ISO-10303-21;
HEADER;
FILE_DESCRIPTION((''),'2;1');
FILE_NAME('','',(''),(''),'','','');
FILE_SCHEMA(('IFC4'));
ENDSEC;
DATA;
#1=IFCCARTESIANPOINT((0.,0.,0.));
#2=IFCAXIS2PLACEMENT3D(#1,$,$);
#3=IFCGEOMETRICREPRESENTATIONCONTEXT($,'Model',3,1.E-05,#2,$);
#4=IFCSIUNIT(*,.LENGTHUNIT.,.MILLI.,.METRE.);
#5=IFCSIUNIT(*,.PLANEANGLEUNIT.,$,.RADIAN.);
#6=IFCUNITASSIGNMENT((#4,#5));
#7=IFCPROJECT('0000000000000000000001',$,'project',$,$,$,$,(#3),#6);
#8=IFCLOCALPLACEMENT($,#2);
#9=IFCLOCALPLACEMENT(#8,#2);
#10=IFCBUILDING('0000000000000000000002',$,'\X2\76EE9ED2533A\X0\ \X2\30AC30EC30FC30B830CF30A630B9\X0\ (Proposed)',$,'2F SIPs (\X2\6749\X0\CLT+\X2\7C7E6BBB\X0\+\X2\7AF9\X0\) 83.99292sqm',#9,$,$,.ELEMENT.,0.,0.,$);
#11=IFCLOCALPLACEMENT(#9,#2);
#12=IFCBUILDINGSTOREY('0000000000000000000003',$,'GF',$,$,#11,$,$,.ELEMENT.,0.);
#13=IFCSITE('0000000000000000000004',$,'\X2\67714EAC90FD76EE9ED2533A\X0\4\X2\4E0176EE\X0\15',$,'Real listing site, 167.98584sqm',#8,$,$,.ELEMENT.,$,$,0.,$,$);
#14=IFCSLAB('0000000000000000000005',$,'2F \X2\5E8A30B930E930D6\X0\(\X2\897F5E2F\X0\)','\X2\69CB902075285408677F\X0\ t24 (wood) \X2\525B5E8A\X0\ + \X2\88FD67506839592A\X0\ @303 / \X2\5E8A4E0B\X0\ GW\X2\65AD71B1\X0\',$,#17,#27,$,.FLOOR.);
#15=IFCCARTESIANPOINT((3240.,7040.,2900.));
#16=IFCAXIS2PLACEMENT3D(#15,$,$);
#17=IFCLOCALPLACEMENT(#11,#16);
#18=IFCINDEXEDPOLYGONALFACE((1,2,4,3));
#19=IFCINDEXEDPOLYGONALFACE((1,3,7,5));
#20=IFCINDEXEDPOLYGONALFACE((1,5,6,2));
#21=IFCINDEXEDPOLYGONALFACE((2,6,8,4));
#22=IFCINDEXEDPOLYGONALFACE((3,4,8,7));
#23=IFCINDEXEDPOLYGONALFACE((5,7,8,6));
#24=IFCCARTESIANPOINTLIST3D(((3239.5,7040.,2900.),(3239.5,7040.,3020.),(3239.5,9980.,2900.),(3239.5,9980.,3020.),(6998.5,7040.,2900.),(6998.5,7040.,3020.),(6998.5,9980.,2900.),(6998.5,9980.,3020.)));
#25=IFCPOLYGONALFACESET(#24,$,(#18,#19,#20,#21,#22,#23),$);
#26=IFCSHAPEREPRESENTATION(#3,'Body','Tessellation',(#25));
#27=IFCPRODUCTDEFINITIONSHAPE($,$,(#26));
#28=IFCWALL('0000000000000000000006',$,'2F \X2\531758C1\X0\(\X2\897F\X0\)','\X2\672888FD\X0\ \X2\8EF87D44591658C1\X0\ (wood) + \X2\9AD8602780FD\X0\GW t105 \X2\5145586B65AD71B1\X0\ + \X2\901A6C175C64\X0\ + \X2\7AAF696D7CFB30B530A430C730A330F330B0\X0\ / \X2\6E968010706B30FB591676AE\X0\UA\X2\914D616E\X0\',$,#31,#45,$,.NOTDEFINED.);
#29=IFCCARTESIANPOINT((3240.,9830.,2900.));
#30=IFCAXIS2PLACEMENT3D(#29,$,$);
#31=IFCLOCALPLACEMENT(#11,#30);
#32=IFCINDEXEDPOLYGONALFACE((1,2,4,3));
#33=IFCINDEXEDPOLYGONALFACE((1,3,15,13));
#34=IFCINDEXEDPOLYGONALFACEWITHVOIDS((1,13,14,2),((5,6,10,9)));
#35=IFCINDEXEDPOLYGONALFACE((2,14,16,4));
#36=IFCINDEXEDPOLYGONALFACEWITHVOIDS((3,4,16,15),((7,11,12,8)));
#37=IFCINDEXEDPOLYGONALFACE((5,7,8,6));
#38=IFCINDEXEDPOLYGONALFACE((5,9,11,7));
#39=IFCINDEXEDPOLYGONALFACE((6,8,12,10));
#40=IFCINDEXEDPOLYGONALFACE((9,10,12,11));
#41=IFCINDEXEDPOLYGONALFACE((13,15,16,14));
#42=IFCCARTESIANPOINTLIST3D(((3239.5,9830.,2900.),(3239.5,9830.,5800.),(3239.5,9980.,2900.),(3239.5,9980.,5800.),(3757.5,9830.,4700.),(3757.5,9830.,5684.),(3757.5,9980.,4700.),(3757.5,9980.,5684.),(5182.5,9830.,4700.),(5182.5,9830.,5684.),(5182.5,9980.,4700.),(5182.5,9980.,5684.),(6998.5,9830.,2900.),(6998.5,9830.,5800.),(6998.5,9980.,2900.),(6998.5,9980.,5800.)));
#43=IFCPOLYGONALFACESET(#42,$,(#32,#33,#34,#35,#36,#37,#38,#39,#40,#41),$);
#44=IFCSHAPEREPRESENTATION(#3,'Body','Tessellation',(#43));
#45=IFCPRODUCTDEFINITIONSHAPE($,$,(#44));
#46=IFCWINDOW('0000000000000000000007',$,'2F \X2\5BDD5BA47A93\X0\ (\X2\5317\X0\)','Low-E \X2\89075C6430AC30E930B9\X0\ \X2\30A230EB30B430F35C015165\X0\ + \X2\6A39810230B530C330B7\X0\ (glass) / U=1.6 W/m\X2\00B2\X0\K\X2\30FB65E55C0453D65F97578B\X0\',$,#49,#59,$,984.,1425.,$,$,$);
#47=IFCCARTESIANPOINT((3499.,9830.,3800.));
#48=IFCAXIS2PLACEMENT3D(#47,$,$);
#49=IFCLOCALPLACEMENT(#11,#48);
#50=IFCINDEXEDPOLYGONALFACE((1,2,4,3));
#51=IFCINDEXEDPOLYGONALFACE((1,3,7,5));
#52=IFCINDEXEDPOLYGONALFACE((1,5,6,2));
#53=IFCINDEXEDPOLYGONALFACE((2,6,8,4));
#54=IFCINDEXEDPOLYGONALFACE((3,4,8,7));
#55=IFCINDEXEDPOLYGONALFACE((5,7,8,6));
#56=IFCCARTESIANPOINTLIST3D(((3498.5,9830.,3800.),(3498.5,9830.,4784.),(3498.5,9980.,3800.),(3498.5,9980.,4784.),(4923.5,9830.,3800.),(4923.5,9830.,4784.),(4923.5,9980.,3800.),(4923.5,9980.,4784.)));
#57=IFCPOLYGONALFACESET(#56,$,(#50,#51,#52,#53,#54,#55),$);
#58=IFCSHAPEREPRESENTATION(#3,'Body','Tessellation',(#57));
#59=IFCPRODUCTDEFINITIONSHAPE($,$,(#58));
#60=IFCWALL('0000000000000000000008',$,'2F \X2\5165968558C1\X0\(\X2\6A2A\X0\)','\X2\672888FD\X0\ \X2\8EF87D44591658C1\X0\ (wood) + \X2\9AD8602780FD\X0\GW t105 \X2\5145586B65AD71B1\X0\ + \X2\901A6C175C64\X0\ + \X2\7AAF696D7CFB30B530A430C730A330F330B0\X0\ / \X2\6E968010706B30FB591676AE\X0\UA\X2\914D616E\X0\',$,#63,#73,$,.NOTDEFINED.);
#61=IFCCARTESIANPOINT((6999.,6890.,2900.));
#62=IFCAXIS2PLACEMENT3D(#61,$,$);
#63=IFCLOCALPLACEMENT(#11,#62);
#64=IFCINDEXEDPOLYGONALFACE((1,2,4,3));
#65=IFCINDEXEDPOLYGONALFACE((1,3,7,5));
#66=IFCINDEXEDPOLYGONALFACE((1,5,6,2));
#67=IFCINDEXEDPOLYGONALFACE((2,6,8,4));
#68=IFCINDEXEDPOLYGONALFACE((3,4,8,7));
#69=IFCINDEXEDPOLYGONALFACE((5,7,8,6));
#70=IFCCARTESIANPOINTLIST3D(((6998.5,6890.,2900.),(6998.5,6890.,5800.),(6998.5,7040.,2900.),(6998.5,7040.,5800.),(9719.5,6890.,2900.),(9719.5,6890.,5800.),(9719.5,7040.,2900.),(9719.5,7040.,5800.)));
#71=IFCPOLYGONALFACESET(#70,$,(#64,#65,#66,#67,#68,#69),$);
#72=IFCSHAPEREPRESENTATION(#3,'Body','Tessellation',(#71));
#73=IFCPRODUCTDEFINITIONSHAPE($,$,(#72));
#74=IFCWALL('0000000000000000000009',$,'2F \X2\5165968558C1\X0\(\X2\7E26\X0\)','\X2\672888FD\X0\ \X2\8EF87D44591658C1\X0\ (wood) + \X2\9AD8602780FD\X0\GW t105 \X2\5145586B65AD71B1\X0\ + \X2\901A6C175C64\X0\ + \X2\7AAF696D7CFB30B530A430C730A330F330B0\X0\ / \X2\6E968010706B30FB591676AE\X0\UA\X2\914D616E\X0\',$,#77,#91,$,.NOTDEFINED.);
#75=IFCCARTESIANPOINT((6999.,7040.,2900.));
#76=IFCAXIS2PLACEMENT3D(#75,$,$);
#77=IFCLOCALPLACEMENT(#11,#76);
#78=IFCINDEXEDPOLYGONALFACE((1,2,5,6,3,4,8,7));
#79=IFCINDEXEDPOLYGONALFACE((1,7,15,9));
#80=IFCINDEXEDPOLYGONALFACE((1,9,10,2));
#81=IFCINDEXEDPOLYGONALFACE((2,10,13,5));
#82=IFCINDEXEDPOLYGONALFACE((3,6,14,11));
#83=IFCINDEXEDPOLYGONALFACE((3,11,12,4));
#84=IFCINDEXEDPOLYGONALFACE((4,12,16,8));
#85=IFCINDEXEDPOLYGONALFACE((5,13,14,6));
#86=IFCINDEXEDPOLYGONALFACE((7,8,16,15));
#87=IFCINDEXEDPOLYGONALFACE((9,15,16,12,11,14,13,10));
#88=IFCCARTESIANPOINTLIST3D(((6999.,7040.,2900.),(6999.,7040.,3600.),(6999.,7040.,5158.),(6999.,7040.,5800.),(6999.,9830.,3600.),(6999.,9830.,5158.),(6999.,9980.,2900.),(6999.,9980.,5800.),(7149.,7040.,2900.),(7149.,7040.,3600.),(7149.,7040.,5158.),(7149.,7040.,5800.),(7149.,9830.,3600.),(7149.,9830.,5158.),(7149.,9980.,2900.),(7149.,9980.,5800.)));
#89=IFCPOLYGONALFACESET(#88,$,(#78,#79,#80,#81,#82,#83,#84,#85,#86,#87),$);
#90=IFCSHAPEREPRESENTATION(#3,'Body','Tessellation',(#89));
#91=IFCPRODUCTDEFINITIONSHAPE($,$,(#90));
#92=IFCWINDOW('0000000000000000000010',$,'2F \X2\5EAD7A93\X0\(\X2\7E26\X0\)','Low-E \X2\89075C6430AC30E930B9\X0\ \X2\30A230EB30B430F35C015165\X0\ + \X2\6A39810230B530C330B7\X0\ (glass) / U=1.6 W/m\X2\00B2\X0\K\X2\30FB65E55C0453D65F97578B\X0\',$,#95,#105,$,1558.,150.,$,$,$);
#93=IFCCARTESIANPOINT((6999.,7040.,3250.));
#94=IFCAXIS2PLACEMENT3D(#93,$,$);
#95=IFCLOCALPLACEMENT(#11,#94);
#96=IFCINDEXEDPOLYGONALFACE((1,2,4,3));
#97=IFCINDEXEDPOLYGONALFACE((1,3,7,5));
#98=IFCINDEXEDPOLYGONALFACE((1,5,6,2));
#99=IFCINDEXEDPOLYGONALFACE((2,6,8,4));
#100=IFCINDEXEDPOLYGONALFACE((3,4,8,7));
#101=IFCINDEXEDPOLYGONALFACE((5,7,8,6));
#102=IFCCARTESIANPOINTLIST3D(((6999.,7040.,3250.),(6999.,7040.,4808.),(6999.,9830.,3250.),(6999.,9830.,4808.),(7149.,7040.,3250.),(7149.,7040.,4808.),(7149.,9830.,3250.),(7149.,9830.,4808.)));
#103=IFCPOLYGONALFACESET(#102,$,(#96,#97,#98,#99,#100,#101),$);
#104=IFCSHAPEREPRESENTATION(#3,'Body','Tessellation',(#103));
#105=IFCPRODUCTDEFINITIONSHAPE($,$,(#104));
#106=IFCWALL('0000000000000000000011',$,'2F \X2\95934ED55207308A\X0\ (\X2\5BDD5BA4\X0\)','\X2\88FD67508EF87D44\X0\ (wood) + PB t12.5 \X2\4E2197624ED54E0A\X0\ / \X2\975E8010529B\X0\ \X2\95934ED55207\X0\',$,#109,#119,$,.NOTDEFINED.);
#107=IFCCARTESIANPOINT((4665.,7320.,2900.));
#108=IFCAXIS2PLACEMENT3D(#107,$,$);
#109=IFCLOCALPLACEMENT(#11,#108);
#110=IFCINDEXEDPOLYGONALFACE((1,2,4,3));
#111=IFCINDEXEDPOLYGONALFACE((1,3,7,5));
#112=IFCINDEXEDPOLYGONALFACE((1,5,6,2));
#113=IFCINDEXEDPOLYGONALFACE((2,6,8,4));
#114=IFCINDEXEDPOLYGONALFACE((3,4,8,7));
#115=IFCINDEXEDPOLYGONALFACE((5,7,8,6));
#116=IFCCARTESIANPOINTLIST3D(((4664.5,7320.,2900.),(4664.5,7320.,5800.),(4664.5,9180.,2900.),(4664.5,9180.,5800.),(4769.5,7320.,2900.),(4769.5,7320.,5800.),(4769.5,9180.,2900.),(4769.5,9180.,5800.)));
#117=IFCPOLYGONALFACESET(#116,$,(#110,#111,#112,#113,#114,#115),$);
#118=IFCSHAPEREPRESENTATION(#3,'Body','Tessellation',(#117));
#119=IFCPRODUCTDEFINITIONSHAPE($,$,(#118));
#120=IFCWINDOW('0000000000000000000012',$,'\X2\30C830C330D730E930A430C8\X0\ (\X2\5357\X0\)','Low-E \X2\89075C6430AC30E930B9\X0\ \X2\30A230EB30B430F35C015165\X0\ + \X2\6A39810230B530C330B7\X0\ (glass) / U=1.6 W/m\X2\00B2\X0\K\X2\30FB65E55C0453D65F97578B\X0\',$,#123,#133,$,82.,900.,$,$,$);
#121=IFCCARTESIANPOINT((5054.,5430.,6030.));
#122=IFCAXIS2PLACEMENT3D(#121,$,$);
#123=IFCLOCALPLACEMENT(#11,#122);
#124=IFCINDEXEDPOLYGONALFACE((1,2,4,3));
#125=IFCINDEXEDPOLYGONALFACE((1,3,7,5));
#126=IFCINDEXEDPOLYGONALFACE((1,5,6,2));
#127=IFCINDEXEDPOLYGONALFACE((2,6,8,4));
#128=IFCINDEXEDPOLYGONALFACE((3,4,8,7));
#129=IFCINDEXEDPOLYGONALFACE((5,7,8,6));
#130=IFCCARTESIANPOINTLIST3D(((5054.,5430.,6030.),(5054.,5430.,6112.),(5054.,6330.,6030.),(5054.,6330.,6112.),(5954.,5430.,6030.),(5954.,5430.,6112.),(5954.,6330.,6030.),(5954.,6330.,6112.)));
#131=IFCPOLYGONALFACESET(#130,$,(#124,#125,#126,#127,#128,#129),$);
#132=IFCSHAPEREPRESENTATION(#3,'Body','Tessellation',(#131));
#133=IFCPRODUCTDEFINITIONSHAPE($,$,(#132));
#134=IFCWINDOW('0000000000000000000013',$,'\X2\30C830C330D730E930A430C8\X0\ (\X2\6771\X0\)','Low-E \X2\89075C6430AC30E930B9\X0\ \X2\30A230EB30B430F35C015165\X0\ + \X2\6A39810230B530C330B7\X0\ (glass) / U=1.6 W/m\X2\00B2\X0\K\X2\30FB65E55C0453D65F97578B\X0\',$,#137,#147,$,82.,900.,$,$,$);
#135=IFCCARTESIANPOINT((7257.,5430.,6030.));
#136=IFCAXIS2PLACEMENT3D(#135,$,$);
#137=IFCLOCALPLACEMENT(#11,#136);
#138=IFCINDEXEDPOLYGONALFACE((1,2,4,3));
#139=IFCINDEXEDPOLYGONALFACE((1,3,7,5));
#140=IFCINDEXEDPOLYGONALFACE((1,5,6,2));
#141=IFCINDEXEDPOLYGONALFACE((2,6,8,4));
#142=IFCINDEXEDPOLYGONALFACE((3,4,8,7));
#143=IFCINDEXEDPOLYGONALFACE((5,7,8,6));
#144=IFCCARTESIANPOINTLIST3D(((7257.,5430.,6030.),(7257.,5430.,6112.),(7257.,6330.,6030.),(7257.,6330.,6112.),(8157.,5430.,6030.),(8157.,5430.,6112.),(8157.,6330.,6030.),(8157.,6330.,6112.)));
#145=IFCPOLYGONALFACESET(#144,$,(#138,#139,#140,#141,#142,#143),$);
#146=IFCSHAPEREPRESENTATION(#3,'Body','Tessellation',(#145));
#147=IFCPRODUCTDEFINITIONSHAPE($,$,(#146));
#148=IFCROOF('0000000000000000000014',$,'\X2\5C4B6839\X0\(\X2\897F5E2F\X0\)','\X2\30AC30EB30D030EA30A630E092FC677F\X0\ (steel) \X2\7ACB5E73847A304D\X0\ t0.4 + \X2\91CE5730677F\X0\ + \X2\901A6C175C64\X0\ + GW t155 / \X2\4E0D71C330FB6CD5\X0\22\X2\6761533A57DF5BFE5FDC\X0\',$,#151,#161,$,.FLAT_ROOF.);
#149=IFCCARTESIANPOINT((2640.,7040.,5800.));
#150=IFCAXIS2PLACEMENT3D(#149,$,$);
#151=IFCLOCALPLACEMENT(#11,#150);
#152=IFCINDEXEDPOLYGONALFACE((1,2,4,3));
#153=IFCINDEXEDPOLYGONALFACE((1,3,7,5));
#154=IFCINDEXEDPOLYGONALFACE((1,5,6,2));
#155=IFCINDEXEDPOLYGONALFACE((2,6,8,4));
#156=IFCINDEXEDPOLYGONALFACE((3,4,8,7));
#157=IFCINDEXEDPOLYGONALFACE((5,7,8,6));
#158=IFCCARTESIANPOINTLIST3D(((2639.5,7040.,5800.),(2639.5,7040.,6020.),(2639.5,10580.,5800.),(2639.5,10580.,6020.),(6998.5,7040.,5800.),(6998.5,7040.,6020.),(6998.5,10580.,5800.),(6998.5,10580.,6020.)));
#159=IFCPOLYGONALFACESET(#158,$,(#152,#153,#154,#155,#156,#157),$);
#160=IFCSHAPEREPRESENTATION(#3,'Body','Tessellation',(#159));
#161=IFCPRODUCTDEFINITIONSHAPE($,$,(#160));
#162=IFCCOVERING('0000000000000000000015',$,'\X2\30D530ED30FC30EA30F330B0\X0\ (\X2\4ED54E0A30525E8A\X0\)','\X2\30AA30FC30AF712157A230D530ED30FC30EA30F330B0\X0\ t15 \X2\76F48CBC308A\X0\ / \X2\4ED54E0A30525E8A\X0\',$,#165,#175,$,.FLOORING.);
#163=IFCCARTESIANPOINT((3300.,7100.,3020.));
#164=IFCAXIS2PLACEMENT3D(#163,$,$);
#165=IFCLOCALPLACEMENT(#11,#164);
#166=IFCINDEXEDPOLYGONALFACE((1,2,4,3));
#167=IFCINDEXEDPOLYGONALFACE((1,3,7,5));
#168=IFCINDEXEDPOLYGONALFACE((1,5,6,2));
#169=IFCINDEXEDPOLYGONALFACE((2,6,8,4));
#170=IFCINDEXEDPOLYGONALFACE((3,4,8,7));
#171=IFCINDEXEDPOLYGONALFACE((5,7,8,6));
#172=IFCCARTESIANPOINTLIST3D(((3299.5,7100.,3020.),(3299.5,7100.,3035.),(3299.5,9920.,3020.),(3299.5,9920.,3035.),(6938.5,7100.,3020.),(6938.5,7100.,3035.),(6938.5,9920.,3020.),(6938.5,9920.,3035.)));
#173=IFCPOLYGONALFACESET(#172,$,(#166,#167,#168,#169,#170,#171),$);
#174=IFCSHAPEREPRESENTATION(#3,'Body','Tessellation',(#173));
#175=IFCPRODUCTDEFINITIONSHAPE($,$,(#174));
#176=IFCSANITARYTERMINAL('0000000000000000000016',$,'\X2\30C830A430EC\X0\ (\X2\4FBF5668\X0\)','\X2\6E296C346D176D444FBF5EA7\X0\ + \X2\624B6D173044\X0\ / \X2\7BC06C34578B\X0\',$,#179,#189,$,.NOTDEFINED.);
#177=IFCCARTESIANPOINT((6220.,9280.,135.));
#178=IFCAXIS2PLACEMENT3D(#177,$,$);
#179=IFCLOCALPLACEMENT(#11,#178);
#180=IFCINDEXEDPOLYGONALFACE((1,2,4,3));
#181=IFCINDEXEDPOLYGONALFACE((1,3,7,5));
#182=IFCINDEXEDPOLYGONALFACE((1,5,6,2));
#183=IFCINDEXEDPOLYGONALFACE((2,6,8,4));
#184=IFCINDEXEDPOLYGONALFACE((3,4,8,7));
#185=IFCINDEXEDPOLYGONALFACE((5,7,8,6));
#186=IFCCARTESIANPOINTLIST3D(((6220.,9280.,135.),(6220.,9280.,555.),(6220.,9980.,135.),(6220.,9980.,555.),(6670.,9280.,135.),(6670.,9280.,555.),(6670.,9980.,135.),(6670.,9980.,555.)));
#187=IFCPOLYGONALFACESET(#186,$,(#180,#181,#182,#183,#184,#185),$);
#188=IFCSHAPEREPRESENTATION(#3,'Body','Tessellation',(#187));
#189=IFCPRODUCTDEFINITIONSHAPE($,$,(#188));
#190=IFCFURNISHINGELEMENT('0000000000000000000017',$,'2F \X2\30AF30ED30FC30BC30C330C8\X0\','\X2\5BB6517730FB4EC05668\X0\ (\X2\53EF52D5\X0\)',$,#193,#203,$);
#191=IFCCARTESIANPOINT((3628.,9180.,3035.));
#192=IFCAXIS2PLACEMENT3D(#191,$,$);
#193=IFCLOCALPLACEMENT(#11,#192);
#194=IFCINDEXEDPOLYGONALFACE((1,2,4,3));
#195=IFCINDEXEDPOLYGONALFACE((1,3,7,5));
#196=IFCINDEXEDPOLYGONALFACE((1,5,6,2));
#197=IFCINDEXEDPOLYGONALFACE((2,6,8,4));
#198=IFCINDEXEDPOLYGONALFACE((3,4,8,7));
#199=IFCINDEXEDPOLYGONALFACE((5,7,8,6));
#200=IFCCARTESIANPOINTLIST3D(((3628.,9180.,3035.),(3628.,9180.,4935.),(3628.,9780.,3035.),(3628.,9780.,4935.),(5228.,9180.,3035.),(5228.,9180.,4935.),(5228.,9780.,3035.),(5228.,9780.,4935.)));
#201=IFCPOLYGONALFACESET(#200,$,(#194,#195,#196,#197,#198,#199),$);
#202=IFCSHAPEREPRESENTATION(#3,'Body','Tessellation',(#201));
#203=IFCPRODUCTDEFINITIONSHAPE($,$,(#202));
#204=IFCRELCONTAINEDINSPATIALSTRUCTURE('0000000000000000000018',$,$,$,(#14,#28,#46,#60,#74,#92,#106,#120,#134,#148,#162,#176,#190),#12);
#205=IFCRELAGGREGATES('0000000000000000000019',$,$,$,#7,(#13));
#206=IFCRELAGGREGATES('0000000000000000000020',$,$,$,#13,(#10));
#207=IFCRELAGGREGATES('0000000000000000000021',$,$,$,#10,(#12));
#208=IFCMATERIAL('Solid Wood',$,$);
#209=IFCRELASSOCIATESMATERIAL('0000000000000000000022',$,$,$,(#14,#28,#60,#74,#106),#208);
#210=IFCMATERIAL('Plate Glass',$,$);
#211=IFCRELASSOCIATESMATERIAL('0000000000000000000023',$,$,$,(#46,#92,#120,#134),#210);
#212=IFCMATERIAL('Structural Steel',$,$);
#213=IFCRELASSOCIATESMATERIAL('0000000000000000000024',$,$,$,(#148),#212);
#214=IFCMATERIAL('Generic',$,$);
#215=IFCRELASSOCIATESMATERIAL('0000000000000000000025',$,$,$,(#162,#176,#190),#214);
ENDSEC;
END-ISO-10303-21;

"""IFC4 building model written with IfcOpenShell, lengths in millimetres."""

from ifc_helpers import new_model, si_unit, frame, frame_2d, origin, place, context, project, spatial, rectangle, extrude, material, element, fill, save


model = new_model("IFC4")

# Units and contexts
model_context = context("Model", 3, precision=1e-05, world=origin())
ifc_project = project(units=[si_unit("LENGTHUNIT", "METRE", prefix="MILLI"), si_unit("PLANEANGLEUNIT", "RADIAN")], contexts=[model_context])

# Site, building, storey
site_placement = place(None, origin())
site = spatial("IfcSite", under=ifc_project, at=site_placement, Name="東京都目黒区4丁目15", ObjectType="Real listing site, 167.98584sqm", CompositionType="ELEMENT", RefElevation=0.0)
building_placement = place(site_placement, origin())
building = spatial("IfcBuilding", under=site, at=building_placement, Name="目黒区 ガレージハウス (Proposed)", ObjectType="2F SIPs (杉CLT+籾殻+竹) 83.99292sqm", CompositionType="ELEMENT", ElevationOfRefHeight=0.0, ElevationOfTerrain=0.0)
storey_placement = place(building_placement, origin())
storey = spatial("IfcBuildingStorey", under=building, at=storey_placement, Name="GF", CompositionType="ELEMENT", Elevation=0.0)

# Slab
ifc_material_1 = material(Name="Solid Wood")
slab_placement = place(storey_placement, frame((3240.0, 7040.0, 2900.0)))
element("IfcSlab", 1, at=slab_placement, inside=storey, material=ifc_material_1, Name="2F 床スラブ(西帯)", Description="構造用合板 t24 (wood) 剛床 + 製材根太 @303 / 床下 GW断熱", PredefinedType="FLOOR", context=model_context, shape_type="SweptSolid", body=[
    extrude(rectangle(XDim=3759.0, YDim=2940.0, at=frame_2d((1879.0, 1470.0))), frame((3240.0, 7040.0, 2900.0)), (0.0, 0.0, 1.0), 120.0),
])

# Wall, opening, window
wall_1_placement = place(storey_placement, frame((3240.0, 9830.0, 2900.0)))
wall_1 = element("IfcWall", 2, at=wall_1_placement, inside=storey, material=ifc_material_1, Name="2F 北壁(西)", Description="木製 軸組外壁 (wood) + 高性能GW t105 充填断熱 + 通気層 + 窯業系サイディング / 準耐火・外皮UA配慮", PredefinedType="NOTDEFINED", context=model_context, shape_type="SweptSolid", body=[
    extrude(rectangle(XDim=3759.0, YDim=150.0, at=frame_2d((1879.0, 75.0))), frame((3240.0, 9830.0, 2900.0)), (0.0, 0.0, 1.0), 2900.0),
])
opening_1_placement = place(storey_placement, frame((3499.0, 9830.0, 3800.0)))
opening_1 = element("IfcOpeningElement", 3, at=opening_1_placement, cuts=wall_1, PredefinedType="NOTDEFINED", context=model_context, shape_type="SweptSolid", body=[
    extrude(rectangle(XDim=1425.0, YDim=150.0, at=frame_2d((712.0, 75.0))), frame((3499.0, 9830.0, 3800.0)), (0.0, 0.0, 1.0), 984.0),
])
ifc_material_2 = material(Name="Plate Glass")
window_1_placement = place(storey_placement, frame((3499.0, 9830.0, 3800.0)))
window_1 = element("IfcWindow", 4, at=window_1_placement, inside=storey, material=ifc_material_2, Name="2F 寝室窓 (北)", Description="Low-E 複層ガラス アルゴン封入 + 樹脂サッシ (glass) / U=1.6 W/m²K・日射取得型", OverallHeight=984.0, OverallWidth=1425.0, context=model_context, shape_type="SweptSolid", body=[
    extrude(rectangle(XDim=1425.0, YDim=150.0, at=frame_2d((712.0, 75.0))), frame((3499.0, 9830.0, 3800.0)), (0.0, 0.0, 1.0), 984.0),
])
fill(opening_1, window_1)

# Wall
wall_2_placement = place(storey_placement, frame((6999.0, 6890.0, 2900.0)))
element("IfcWall", 5, at=wall_2_placement, inside=storey, material=ifc_material_1, Name="2F 入隅壁(横)", Description="木製 軸組外壁 (wood) + 高性能GW t105 充填断熱 + 通気層 + 窯業系サイディング / 準耐火・外皮UA配慮", PredefinedType="NOTDEFINED", context=model_context, shape_type="SweptSolid", body=[
    extrude(rectangle(XDim=2721.0, YDim=150.0, at=frame_2d((1360.0, 75.0))), frame((6999.0, 6890.0, 2900.0)), (0.0, 0.0, 1.0), 2900.0),
])

# Wall, opening, window
wall_3_placement = place(storey_placement, frame((6999.0, 7040.0, 2900.0)))
wall_3 = element("IfcWall", 6, at=wall_3_placement, inside=storey, material=ifc_material_1, Name="2F 入隅壁(縦)", Description="木製 軸組外壁 (wood) + 高性能GW t105 充填断熱 + 通気層 + 窯業系サイディング / 準耐火・外皮UA配慮", PredefinedType="NOTDEFINED", context=model_context, shape_type="SweptSolid", body=[
    extrude(rectangle(XDim=150.0, YDim=2940.0, at=frame_2d((75.0, 1470.0))), frame((6999.0, 7040.0, 2900.0)), (0.0, 0.0, 1.0), 2900.0),
])
opening_2_placement = place(storey_placement, frame((6999.0, 7040.0, 3250.0)))
opening_2 = element("IfcOpeningElement", 7, at=opening_2_placement, cuts=wall_3, PredefinedType="NOTDEFINED", context=model_context, shape_type="SweptSolid", body=[
    extrude(rectangle(XDim=150.0, YDim=2790.0, at=frame_2d((75.0, 1395.0))), frame((6999.0, 7040.0, 3250.0)), (0.0, 0.0, 1.0), 1558.0),
])
window_2_placement = place(storey_placement, frame((6999.0, 7040.0, 3250.0)))
window_2 = element("IfcWindow", 8, at=window_2_placement, inside=storey, material=ifc_material_2, Name="2F 庭窓(縦)", Description="Low-E 複層ガラス アルゴン封入 + 樹脂サッシ (glass) / U=1.6 W/m²K・日射取得型", OverallHeight=1558.0, OverallWidth=150.0, context=model_context, shape_type="SweptSolid", body=[
    extrude(rectangle(XDim=150.0, YDim=2790.0, at=frame_2d((75.0, 1395.0))), frame((6999.0, 7040.0, 3250.0)), (0.0, 0.0, 1.0), 1558.0),
])
fill(opening_2, window_2)

# Wall
wall_4_placement = place(storey_placement, frame((4665.0, 7320.0, 2900.0)))
element("IfcWall", 9, at=wall_4_placement, inside=storey, material=ifc_material_1, Name="2F 間仕切り (寝室)", Description="製材軸組 (wood) + PB t12.5 両面仕上 / 非耐力 間仕切", PredefinedType="NOTDEFINED", context=model_context, shape_type="SweptSolid", body=[
    extrude(rectangle(XDim=105.0, YDim=1860.0, at=frame_2d((52.0, 930.0))), frame((4665.0, 7320.0, 2900.0)), (0.0, 0.0, 1.0), 2900.0),
])

# Windows
window_3_placement = place(storey_placement, frame((5054.0, 5430.0, 6030.0)))
element("IfcWindow", 10, at=window_3_placement, inside=storey, material=ifc_material_2, Name="トップライト (南)", Description="Low-E 複層ガラス アルゴン封入 + 樹脂サッシ (glass) / U=1.6 W/m²K・日射取得型", OverallHeight=82.0, OverallWidth=900.0, context=model_context, shape_type="SweptSolid", body=[
    extrude(rectangle(XDim=900.0, YDim=900.0, at=frame_2d((450.0, 450.0))), frame((5054.0, 5430.0, 6030.0)), (0.0, 0.0, 1.0), 82.0),
])
window_4_placement = place(storey_placement, frame((7257.0, 5430.0, 6030.0)))
element("IfcWindow", 11, at=window_4_placement, inside=storey, material=ifc_material_2, Name="トップライト (東)", Description="Low-E 複層ガラス アルゴン封入 + 樹脂サッシ (glass) / U=1.6 W/m²K・日射取得型", OverallHeight=82.0, OverallWidth=900.0, context=model_context, shape_type="SweptSolid", body=[
    extrude(rectangle(XDim=900.0, YDim=900.0, at=frame_2d((450.0, 450.0))), frame((7257.0, 5430.0, 6030.0)), (0.0, 0.0, 1.0), 82.0),
])

# Roof
ifc_material_3 = material(Name="Structural Steel")
for number, where, name in (
    (12, (2640.0, 7040.0, 5800.0), "屋根(西帯)"),
):
    element("IfcRoof", number, at=place(storey_placement, frame(where)), inside=storey, material=ifc_material_3, Name=name, Description="ガルバリウム鋼板 (steel) 立平葺き t0.4 + 野地板 + 通気層 + GW t155 / 不燃・法22条区域対応", PredefinedType="FLAT_ROOF", context=model_context, shape_type="SweptSolid", body=[
        extrude(rectangle(XDim=4359.0, YDim=3540.0, at=frame_2d((2179.0, 1770.0))), frame((2640.0, 7040.0, 5800.0)), (0.0, 0.0, 1.0), 220.0),
    ])

# Covering
ifc_material_4 = material(Name="Generic")
covering_placement = place(storey_placement, frame((3300.0, 7100.0, 3020.0)))
element("IfcCovering", 13, at=covering_placement, inside=storey, material=ifc_material_4, Name="フローリング (仕上げ床)", Description="オーク無垢フローリング t15 直貼り / 仕上げ床", PredefinedType="FLOORING", context=model_context, shape_type="SweptSolid", body=[
    extrude(rectangle(XDim=3639.0, YDim=2820.0, at=frame_2d((1819.0, 1410.0))), frame((3300.0, 7100.0, 3020.0)), (0.0, 0.0, 1.0), 15.0),
])

# Sanitary terminal
sanitary_terminal_placement = place(storey_placement, frame((6220.0, 9280.0, 135.0)))
element("IfcSanitaryTerminal", 14, at=sanitary_terminal_placement, inside=storey, material=ifc_material_4, Name="トイレ (便器)", Description="温水洗浄便座 + 手洗い / 節水型", PredefinedType="NOTDEFINED", context=model_context, shape_type="SweptSolid", body=[
    extrude(rectangle(XDim=450.0, YDim=700.0, at=frame_2d((225.0, 350.0))), frame((6220.0, 9280.0, 135.0)), (0.0, 0.0, 1.0), 420.0),
])

# Furnishing element
furnishing_1_placement = place(storey_placement, frame((3628.0, 9180.0, 3035.0)))
element("IfcFurnishingElement", 15, at=furnishing_1_placement, inside=storey, material=ifc_material_4, Name="2F クローゼット", Description="家具・什器 (可動)", context=model_context, shape_type="SweptSolid", body=[
    extrude(rectangle(XDim=1600.0, YDim=600.0, at=frame_2d((800.0, 300.0))), frame((3628.0, 9180.0, 3035.0)), (0.0, 0.0, 1.0), 1900.0),
])

save(model, "model.ifc")
